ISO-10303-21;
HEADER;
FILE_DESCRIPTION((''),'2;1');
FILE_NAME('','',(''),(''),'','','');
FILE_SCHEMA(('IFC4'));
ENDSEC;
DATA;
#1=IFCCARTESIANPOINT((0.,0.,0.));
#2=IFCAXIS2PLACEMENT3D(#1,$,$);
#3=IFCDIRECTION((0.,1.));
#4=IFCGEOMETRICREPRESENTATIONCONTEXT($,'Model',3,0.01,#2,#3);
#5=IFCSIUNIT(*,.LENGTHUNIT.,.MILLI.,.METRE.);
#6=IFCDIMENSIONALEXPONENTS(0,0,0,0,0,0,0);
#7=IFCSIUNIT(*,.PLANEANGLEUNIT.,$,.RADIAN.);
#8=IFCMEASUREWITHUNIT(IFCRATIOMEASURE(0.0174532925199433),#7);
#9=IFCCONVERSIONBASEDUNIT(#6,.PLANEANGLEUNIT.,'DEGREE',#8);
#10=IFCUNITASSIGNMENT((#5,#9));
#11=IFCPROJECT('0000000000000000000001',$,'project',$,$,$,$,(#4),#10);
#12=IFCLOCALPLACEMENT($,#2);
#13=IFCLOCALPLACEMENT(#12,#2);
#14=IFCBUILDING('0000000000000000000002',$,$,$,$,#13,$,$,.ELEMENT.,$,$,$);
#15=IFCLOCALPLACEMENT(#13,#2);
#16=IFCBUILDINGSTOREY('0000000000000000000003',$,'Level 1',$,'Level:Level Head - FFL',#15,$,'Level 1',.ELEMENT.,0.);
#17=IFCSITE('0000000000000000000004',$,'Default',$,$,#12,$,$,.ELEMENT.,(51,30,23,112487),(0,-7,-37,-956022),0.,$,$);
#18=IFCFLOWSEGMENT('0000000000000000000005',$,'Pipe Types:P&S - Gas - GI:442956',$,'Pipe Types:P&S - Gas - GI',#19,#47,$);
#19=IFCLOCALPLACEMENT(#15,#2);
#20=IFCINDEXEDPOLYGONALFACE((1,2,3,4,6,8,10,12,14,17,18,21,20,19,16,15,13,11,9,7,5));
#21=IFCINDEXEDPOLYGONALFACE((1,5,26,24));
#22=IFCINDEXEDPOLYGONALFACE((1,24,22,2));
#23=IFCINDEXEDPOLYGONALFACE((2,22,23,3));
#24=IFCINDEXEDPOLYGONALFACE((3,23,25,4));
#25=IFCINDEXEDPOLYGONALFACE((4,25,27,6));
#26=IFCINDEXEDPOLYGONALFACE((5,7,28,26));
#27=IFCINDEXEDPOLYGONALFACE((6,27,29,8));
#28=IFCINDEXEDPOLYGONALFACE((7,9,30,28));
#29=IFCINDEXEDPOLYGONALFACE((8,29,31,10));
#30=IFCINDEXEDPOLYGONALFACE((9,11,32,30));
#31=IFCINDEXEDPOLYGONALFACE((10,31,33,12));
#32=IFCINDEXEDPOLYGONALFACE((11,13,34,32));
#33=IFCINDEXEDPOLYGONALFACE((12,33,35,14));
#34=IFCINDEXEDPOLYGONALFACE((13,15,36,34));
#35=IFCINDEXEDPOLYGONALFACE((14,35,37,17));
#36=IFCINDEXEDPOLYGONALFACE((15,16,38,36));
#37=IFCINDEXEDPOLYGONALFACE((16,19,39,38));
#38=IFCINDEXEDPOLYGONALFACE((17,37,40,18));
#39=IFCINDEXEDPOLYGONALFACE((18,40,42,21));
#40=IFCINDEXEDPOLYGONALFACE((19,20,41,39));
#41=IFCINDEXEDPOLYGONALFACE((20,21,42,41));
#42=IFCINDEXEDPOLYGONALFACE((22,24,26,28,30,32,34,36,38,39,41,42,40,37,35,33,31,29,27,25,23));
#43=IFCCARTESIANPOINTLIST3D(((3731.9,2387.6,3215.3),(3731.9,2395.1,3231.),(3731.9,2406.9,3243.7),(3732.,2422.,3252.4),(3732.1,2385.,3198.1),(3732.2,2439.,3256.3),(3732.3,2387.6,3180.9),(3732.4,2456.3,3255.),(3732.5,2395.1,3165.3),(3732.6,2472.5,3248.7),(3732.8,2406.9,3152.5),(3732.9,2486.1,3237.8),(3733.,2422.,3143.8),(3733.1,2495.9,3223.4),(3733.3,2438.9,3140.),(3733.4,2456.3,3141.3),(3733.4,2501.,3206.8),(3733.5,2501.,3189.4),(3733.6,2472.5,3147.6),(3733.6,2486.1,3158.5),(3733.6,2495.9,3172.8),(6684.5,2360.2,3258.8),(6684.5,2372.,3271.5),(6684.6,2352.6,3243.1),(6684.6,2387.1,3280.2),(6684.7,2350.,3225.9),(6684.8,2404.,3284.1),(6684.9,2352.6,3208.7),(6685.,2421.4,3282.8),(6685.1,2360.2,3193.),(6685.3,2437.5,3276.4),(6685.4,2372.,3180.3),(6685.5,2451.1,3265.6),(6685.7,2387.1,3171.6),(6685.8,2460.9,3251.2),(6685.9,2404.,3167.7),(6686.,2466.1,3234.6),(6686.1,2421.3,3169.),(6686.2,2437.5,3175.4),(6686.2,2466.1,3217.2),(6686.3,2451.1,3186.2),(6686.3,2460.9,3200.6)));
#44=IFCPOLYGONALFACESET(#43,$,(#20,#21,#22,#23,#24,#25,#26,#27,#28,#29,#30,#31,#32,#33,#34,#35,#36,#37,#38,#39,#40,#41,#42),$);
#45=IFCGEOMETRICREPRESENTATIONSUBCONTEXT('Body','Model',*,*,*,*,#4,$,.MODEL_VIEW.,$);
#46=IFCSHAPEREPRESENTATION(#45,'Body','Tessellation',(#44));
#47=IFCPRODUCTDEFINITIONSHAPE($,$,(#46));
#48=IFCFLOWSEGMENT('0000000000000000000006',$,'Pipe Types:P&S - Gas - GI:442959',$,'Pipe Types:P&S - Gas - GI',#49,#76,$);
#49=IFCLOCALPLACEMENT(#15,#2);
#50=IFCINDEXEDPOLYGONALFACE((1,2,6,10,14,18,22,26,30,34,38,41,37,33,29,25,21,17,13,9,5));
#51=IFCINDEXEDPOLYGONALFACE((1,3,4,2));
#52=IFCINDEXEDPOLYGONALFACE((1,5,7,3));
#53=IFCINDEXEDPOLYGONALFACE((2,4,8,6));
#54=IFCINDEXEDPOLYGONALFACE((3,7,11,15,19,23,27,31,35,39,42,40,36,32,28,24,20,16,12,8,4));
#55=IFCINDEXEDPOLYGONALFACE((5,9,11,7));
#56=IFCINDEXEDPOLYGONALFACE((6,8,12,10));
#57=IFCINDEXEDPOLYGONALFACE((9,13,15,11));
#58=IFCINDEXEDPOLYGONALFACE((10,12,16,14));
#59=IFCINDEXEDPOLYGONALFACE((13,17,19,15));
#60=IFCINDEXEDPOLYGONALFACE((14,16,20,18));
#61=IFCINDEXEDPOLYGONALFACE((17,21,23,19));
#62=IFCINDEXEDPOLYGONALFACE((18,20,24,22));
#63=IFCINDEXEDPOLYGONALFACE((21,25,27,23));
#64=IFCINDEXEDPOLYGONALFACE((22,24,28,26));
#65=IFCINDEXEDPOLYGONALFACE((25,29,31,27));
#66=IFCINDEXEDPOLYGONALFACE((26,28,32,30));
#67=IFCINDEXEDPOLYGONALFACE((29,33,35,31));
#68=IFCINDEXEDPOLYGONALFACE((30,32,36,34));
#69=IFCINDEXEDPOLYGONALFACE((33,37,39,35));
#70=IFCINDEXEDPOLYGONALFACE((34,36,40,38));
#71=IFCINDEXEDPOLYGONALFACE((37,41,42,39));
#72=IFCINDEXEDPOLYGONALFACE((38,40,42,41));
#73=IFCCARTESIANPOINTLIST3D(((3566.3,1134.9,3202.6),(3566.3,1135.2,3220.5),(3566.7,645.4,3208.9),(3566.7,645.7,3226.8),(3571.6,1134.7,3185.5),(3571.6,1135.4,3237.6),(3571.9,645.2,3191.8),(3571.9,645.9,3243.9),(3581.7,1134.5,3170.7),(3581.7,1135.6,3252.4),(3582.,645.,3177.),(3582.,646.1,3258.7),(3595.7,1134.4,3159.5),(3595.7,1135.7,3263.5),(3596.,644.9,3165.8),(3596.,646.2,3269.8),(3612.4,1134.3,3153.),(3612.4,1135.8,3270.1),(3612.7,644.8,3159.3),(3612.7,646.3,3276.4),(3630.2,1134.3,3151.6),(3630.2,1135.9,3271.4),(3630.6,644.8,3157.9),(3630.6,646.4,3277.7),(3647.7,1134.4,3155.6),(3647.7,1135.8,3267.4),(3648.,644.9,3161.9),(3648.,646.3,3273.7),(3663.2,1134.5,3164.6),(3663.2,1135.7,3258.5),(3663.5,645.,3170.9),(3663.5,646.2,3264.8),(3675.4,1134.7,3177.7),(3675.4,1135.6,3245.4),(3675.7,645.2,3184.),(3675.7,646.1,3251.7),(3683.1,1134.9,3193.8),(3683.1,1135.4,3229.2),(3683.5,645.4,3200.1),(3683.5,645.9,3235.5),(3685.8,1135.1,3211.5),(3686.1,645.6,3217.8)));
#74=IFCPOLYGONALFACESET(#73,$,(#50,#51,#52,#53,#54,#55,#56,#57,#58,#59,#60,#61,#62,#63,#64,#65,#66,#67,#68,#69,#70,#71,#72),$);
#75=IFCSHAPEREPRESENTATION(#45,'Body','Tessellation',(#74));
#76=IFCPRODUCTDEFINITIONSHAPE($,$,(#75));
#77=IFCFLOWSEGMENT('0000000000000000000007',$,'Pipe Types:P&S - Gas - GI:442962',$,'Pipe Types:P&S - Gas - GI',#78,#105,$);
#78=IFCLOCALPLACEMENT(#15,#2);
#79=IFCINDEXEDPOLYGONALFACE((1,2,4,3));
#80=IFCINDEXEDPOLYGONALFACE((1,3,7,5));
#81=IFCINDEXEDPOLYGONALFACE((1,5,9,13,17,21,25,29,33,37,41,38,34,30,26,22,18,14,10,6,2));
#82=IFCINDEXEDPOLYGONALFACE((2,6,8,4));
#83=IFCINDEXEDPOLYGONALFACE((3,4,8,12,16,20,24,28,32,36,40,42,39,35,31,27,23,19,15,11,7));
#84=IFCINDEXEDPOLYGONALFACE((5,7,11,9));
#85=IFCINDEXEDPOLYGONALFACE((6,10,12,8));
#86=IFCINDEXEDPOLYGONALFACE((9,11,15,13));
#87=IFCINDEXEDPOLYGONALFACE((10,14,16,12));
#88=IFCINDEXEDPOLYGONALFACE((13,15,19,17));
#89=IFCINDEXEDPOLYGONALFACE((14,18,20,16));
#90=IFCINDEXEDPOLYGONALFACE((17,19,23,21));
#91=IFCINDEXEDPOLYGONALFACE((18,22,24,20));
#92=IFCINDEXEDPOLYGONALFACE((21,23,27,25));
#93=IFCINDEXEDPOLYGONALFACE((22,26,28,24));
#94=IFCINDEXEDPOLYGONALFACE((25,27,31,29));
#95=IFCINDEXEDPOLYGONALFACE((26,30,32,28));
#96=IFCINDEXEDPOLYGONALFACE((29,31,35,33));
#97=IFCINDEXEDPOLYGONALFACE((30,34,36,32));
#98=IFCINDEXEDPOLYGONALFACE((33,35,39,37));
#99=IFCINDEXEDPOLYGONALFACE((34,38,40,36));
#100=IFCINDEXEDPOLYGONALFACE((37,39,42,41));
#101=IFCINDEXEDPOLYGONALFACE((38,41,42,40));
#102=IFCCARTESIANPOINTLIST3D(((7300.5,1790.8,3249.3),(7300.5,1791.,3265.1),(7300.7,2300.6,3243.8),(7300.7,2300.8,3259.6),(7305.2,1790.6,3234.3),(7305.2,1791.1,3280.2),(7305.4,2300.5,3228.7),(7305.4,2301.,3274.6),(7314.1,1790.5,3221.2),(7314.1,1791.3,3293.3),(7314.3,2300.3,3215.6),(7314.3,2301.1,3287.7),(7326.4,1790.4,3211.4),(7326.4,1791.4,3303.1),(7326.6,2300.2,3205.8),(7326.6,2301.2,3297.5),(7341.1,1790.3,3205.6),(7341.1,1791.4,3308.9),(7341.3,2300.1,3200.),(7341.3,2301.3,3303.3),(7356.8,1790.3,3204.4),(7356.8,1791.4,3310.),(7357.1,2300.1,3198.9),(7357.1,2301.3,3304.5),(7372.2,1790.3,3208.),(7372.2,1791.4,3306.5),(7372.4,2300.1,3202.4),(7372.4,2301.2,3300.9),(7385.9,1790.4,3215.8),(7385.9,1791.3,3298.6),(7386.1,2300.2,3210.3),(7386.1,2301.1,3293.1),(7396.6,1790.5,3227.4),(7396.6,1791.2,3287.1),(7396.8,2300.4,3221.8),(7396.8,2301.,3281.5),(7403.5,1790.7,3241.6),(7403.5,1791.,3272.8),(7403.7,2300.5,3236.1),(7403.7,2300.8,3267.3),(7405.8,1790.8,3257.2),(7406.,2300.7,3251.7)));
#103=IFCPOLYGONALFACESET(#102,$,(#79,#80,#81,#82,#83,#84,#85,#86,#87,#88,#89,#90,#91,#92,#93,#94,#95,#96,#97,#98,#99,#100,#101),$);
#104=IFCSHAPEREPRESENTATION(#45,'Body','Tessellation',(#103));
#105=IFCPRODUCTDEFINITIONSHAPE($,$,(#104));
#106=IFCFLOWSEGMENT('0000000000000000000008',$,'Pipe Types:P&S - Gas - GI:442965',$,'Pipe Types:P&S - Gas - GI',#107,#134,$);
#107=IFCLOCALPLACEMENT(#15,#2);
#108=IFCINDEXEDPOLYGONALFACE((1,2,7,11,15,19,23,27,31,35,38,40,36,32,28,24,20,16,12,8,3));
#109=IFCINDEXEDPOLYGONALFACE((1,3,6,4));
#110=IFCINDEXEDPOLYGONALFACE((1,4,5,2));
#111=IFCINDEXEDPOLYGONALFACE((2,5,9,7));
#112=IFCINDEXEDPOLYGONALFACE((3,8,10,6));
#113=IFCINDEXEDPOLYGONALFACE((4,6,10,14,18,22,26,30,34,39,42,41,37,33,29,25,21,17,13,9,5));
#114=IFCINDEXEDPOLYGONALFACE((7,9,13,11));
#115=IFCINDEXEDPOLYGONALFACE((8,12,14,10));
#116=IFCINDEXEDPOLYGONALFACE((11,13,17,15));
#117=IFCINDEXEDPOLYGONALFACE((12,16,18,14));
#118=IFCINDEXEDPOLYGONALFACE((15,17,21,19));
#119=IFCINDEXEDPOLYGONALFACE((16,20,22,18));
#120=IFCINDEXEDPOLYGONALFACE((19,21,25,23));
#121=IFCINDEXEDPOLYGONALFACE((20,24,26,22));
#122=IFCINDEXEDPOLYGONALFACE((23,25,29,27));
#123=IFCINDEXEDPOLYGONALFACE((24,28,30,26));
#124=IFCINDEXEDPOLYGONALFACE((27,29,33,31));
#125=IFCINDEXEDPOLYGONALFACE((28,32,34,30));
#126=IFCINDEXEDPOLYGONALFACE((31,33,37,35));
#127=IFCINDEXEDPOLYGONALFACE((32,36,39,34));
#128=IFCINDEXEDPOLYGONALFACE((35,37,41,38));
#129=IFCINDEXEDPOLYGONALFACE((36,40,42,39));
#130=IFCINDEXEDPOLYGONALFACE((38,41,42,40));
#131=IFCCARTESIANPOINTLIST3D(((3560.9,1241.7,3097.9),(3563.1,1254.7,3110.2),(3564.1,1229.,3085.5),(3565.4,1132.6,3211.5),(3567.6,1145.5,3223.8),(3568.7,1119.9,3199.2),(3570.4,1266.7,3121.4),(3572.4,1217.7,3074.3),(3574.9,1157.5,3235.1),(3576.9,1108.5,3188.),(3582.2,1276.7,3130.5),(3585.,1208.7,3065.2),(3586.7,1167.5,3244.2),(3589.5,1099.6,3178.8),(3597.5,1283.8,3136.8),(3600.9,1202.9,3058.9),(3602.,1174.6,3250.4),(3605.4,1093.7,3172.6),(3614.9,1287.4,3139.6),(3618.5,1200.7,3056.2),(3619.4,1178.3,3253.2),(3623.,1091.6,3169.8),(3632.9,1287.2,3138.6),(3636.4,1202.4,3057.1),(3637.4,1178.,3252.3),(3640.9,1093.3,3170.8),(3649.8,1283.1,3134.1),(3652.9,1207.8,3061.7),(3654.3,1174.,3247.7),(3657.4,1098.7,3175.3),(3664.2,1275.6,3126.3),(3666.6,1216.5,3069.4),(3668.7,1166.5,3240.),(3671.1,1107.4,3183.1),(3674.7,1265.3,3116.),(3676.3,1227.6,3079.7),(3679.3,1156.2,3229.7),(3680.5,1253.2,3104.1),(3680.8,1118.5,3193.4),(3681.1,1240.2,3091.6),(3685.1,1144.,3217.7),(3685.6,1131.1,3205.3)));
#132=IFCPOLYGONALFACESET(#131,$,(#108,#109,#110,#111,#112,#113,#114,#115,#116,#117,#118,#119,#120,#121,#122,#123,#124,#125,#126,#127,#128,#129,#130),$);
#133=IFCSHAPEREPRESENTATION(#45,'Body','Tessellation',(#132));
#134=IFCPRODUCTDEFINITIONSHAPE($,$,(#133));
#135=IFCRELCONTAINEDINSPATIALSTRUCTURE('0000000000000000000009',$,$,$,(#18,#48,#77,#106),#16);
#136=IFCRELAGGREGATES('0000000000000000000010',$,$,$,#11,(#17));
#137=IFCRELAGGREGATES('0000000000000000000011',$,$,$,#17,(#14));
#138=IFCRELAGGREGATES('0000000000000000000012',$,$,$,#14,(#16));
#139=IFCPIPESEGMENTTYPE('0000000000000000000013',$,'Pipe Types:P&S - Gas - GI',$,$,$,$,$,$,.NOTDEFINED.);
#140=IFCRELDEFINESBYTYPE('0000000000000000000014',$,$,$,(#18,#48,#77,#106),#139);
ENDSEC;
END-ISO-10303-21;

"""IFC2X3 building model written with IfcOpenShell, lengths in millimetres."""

from ifc_helpers import new_model, entity, si_unit, converted_unit, direction, frame, frame_2d, origin, origin_2d_with_axis, place, context, subcontext, project, spatial, circle, extrude, type_object, element, save


model = new_model("IFC2X3")

# Units and contexts
model_context = context("Model", 3, precision=0.01, world=origin(), true_north=direction((0.0, 1.0)))
body_context = subcontext(model_context, "Body", "Model", "MODEL_VIEW")
ifc_project = project(units=[si_unit("LENGTHUNIT", "METRE", prefix="MILLI"), converted_unit("PLANEANGLEUNIT", "DEGREE", entity("IfcRatioMeasure", 0.0174532925199433), si_unit("PLANEANGLEUNIT", "RADIAN"), dimensions=[0, 0, 0, 0, 0, 0, 0])], contexts=[model_context])

# Site, building, storey
site_placement = place(None, origin())
site = spatial("IfcSite", under=ifc_project, at=site_placement, Name="Default", CompositionType="ELEMENT", RefLatitude=(51, 30, 23, 112487), RefLongitude=(0, -7, -37, -956022), RefElevation=0.0)
building_placement = place(site_placement, origin())
building = spatial("IfcBuilding", under=site, at=building_placement, CompositionType="ELEMENT")
storey_placement = place(building_placement, origin())
storey = spatial("IfcBuildingStorey", under=building, at=storey_placement, Name="Level 1", ObjectType="Level:Level Head - FFL", LongName="Level 1", CompositionType="ELEMENT", Elevation=0.0)

# Flow segments
pipe_segment_type = type_object("IfcPipeSegmentType", Name="Pipe Types:P&S - Gas - GI", PredefinedType="NOTDEFINED")
flow_segment_1_placement = place(storey_placement, origin())
element("IfcFlowSegment", 1, at=flow_segment_1_placement, inside=storey, type_object=pipe_segment_type, Name="Pipe Types:P&S - Gas - GI:442956", ObjectType="Pipe Types:P&S - Gas - GI", context=body_context, shape_type="SweptSolid", body=[
    extrude(circle(Radius=58.3, at=origin_2d_with_axis()), frame((3732.8, 2443.3, 3198.1), z_axis=(0.999886, -0.011831, 0.009402), x_axis=(-0.011832, -0.99993, 0.0)), (0.0, 0.0, 1.0), 2953.0),
])
flow_segment_2_placement = place(storey_placement, origin())
element("IfcFlowSegment", 2, at=flow_segment_2_placement, inside=storey, type_object=pipe_segment_type, Name="Pipe Types:P&S - Gas - GI:442959", ObjectType="Pipe Types:P&S - Gas - GI", context=body_context, shape_type="SweptSolid", body=[
    extrude(circle(Radius=60.1, at=frame_2d((0.0, 0.0), x_axis=(1.0, 0.0))), frame((3625.7, 1135.1, 3211.5), z_axis=(0.00069, -0.999917, 0.012883), x_axis=(1.0, 0.00069, 0.0)), (0.0, 0.0, 1.0), 489.6),
])
flow_segment_3_placement = place(storey_placement, origin())
element("IfcFlowSegment", 3, at=flow_segment_3_placement, inside=storey, type_object=pipe_segment_type, Name="Pipe Types:P&S - Gas - GI:442962", ObjectType="Pipe Types:P&S - Gas - GI", context=body_context, shape_type="SweptSolid", body=[
    extrude(circle(Radius=53.0, at=origin_2d_with_axis()), frame((7353.1, 2300.7, 3251.7), z_axis=(-0.000438, -0.99994, 0.010942), x_axis=(1.0, -0.000438, 0.0)), (0.0, 0.0, 1.0), 509.9),
])
flow_segment_4_placement = place(storey_placement, origin())
element("IfcFlowSegment", 4, at=flow_segment_4_placement, inside=storey, type_object=pipe_segment_type, Name="Pipe Types:P&S - Gas - GI:442965", ObjectType="Pipe Types:P&S - Gas - GI", context=body_context, shape_type="SweptSolid", body=[
    extrude(circle(Radius=60.3, at=frame_2d((0.0, 0.0), x_axis=(1.0, 0.0))), frame((3621.2, 1244.2, 3097.9), z_axis=(0.028678, -0.692358, 0.720984), x_axis=(-0.999143, -0.041385, 0.0)), (0.0, 0.0, 1.0), 157.6),
])

save(model, "model.ifc")
